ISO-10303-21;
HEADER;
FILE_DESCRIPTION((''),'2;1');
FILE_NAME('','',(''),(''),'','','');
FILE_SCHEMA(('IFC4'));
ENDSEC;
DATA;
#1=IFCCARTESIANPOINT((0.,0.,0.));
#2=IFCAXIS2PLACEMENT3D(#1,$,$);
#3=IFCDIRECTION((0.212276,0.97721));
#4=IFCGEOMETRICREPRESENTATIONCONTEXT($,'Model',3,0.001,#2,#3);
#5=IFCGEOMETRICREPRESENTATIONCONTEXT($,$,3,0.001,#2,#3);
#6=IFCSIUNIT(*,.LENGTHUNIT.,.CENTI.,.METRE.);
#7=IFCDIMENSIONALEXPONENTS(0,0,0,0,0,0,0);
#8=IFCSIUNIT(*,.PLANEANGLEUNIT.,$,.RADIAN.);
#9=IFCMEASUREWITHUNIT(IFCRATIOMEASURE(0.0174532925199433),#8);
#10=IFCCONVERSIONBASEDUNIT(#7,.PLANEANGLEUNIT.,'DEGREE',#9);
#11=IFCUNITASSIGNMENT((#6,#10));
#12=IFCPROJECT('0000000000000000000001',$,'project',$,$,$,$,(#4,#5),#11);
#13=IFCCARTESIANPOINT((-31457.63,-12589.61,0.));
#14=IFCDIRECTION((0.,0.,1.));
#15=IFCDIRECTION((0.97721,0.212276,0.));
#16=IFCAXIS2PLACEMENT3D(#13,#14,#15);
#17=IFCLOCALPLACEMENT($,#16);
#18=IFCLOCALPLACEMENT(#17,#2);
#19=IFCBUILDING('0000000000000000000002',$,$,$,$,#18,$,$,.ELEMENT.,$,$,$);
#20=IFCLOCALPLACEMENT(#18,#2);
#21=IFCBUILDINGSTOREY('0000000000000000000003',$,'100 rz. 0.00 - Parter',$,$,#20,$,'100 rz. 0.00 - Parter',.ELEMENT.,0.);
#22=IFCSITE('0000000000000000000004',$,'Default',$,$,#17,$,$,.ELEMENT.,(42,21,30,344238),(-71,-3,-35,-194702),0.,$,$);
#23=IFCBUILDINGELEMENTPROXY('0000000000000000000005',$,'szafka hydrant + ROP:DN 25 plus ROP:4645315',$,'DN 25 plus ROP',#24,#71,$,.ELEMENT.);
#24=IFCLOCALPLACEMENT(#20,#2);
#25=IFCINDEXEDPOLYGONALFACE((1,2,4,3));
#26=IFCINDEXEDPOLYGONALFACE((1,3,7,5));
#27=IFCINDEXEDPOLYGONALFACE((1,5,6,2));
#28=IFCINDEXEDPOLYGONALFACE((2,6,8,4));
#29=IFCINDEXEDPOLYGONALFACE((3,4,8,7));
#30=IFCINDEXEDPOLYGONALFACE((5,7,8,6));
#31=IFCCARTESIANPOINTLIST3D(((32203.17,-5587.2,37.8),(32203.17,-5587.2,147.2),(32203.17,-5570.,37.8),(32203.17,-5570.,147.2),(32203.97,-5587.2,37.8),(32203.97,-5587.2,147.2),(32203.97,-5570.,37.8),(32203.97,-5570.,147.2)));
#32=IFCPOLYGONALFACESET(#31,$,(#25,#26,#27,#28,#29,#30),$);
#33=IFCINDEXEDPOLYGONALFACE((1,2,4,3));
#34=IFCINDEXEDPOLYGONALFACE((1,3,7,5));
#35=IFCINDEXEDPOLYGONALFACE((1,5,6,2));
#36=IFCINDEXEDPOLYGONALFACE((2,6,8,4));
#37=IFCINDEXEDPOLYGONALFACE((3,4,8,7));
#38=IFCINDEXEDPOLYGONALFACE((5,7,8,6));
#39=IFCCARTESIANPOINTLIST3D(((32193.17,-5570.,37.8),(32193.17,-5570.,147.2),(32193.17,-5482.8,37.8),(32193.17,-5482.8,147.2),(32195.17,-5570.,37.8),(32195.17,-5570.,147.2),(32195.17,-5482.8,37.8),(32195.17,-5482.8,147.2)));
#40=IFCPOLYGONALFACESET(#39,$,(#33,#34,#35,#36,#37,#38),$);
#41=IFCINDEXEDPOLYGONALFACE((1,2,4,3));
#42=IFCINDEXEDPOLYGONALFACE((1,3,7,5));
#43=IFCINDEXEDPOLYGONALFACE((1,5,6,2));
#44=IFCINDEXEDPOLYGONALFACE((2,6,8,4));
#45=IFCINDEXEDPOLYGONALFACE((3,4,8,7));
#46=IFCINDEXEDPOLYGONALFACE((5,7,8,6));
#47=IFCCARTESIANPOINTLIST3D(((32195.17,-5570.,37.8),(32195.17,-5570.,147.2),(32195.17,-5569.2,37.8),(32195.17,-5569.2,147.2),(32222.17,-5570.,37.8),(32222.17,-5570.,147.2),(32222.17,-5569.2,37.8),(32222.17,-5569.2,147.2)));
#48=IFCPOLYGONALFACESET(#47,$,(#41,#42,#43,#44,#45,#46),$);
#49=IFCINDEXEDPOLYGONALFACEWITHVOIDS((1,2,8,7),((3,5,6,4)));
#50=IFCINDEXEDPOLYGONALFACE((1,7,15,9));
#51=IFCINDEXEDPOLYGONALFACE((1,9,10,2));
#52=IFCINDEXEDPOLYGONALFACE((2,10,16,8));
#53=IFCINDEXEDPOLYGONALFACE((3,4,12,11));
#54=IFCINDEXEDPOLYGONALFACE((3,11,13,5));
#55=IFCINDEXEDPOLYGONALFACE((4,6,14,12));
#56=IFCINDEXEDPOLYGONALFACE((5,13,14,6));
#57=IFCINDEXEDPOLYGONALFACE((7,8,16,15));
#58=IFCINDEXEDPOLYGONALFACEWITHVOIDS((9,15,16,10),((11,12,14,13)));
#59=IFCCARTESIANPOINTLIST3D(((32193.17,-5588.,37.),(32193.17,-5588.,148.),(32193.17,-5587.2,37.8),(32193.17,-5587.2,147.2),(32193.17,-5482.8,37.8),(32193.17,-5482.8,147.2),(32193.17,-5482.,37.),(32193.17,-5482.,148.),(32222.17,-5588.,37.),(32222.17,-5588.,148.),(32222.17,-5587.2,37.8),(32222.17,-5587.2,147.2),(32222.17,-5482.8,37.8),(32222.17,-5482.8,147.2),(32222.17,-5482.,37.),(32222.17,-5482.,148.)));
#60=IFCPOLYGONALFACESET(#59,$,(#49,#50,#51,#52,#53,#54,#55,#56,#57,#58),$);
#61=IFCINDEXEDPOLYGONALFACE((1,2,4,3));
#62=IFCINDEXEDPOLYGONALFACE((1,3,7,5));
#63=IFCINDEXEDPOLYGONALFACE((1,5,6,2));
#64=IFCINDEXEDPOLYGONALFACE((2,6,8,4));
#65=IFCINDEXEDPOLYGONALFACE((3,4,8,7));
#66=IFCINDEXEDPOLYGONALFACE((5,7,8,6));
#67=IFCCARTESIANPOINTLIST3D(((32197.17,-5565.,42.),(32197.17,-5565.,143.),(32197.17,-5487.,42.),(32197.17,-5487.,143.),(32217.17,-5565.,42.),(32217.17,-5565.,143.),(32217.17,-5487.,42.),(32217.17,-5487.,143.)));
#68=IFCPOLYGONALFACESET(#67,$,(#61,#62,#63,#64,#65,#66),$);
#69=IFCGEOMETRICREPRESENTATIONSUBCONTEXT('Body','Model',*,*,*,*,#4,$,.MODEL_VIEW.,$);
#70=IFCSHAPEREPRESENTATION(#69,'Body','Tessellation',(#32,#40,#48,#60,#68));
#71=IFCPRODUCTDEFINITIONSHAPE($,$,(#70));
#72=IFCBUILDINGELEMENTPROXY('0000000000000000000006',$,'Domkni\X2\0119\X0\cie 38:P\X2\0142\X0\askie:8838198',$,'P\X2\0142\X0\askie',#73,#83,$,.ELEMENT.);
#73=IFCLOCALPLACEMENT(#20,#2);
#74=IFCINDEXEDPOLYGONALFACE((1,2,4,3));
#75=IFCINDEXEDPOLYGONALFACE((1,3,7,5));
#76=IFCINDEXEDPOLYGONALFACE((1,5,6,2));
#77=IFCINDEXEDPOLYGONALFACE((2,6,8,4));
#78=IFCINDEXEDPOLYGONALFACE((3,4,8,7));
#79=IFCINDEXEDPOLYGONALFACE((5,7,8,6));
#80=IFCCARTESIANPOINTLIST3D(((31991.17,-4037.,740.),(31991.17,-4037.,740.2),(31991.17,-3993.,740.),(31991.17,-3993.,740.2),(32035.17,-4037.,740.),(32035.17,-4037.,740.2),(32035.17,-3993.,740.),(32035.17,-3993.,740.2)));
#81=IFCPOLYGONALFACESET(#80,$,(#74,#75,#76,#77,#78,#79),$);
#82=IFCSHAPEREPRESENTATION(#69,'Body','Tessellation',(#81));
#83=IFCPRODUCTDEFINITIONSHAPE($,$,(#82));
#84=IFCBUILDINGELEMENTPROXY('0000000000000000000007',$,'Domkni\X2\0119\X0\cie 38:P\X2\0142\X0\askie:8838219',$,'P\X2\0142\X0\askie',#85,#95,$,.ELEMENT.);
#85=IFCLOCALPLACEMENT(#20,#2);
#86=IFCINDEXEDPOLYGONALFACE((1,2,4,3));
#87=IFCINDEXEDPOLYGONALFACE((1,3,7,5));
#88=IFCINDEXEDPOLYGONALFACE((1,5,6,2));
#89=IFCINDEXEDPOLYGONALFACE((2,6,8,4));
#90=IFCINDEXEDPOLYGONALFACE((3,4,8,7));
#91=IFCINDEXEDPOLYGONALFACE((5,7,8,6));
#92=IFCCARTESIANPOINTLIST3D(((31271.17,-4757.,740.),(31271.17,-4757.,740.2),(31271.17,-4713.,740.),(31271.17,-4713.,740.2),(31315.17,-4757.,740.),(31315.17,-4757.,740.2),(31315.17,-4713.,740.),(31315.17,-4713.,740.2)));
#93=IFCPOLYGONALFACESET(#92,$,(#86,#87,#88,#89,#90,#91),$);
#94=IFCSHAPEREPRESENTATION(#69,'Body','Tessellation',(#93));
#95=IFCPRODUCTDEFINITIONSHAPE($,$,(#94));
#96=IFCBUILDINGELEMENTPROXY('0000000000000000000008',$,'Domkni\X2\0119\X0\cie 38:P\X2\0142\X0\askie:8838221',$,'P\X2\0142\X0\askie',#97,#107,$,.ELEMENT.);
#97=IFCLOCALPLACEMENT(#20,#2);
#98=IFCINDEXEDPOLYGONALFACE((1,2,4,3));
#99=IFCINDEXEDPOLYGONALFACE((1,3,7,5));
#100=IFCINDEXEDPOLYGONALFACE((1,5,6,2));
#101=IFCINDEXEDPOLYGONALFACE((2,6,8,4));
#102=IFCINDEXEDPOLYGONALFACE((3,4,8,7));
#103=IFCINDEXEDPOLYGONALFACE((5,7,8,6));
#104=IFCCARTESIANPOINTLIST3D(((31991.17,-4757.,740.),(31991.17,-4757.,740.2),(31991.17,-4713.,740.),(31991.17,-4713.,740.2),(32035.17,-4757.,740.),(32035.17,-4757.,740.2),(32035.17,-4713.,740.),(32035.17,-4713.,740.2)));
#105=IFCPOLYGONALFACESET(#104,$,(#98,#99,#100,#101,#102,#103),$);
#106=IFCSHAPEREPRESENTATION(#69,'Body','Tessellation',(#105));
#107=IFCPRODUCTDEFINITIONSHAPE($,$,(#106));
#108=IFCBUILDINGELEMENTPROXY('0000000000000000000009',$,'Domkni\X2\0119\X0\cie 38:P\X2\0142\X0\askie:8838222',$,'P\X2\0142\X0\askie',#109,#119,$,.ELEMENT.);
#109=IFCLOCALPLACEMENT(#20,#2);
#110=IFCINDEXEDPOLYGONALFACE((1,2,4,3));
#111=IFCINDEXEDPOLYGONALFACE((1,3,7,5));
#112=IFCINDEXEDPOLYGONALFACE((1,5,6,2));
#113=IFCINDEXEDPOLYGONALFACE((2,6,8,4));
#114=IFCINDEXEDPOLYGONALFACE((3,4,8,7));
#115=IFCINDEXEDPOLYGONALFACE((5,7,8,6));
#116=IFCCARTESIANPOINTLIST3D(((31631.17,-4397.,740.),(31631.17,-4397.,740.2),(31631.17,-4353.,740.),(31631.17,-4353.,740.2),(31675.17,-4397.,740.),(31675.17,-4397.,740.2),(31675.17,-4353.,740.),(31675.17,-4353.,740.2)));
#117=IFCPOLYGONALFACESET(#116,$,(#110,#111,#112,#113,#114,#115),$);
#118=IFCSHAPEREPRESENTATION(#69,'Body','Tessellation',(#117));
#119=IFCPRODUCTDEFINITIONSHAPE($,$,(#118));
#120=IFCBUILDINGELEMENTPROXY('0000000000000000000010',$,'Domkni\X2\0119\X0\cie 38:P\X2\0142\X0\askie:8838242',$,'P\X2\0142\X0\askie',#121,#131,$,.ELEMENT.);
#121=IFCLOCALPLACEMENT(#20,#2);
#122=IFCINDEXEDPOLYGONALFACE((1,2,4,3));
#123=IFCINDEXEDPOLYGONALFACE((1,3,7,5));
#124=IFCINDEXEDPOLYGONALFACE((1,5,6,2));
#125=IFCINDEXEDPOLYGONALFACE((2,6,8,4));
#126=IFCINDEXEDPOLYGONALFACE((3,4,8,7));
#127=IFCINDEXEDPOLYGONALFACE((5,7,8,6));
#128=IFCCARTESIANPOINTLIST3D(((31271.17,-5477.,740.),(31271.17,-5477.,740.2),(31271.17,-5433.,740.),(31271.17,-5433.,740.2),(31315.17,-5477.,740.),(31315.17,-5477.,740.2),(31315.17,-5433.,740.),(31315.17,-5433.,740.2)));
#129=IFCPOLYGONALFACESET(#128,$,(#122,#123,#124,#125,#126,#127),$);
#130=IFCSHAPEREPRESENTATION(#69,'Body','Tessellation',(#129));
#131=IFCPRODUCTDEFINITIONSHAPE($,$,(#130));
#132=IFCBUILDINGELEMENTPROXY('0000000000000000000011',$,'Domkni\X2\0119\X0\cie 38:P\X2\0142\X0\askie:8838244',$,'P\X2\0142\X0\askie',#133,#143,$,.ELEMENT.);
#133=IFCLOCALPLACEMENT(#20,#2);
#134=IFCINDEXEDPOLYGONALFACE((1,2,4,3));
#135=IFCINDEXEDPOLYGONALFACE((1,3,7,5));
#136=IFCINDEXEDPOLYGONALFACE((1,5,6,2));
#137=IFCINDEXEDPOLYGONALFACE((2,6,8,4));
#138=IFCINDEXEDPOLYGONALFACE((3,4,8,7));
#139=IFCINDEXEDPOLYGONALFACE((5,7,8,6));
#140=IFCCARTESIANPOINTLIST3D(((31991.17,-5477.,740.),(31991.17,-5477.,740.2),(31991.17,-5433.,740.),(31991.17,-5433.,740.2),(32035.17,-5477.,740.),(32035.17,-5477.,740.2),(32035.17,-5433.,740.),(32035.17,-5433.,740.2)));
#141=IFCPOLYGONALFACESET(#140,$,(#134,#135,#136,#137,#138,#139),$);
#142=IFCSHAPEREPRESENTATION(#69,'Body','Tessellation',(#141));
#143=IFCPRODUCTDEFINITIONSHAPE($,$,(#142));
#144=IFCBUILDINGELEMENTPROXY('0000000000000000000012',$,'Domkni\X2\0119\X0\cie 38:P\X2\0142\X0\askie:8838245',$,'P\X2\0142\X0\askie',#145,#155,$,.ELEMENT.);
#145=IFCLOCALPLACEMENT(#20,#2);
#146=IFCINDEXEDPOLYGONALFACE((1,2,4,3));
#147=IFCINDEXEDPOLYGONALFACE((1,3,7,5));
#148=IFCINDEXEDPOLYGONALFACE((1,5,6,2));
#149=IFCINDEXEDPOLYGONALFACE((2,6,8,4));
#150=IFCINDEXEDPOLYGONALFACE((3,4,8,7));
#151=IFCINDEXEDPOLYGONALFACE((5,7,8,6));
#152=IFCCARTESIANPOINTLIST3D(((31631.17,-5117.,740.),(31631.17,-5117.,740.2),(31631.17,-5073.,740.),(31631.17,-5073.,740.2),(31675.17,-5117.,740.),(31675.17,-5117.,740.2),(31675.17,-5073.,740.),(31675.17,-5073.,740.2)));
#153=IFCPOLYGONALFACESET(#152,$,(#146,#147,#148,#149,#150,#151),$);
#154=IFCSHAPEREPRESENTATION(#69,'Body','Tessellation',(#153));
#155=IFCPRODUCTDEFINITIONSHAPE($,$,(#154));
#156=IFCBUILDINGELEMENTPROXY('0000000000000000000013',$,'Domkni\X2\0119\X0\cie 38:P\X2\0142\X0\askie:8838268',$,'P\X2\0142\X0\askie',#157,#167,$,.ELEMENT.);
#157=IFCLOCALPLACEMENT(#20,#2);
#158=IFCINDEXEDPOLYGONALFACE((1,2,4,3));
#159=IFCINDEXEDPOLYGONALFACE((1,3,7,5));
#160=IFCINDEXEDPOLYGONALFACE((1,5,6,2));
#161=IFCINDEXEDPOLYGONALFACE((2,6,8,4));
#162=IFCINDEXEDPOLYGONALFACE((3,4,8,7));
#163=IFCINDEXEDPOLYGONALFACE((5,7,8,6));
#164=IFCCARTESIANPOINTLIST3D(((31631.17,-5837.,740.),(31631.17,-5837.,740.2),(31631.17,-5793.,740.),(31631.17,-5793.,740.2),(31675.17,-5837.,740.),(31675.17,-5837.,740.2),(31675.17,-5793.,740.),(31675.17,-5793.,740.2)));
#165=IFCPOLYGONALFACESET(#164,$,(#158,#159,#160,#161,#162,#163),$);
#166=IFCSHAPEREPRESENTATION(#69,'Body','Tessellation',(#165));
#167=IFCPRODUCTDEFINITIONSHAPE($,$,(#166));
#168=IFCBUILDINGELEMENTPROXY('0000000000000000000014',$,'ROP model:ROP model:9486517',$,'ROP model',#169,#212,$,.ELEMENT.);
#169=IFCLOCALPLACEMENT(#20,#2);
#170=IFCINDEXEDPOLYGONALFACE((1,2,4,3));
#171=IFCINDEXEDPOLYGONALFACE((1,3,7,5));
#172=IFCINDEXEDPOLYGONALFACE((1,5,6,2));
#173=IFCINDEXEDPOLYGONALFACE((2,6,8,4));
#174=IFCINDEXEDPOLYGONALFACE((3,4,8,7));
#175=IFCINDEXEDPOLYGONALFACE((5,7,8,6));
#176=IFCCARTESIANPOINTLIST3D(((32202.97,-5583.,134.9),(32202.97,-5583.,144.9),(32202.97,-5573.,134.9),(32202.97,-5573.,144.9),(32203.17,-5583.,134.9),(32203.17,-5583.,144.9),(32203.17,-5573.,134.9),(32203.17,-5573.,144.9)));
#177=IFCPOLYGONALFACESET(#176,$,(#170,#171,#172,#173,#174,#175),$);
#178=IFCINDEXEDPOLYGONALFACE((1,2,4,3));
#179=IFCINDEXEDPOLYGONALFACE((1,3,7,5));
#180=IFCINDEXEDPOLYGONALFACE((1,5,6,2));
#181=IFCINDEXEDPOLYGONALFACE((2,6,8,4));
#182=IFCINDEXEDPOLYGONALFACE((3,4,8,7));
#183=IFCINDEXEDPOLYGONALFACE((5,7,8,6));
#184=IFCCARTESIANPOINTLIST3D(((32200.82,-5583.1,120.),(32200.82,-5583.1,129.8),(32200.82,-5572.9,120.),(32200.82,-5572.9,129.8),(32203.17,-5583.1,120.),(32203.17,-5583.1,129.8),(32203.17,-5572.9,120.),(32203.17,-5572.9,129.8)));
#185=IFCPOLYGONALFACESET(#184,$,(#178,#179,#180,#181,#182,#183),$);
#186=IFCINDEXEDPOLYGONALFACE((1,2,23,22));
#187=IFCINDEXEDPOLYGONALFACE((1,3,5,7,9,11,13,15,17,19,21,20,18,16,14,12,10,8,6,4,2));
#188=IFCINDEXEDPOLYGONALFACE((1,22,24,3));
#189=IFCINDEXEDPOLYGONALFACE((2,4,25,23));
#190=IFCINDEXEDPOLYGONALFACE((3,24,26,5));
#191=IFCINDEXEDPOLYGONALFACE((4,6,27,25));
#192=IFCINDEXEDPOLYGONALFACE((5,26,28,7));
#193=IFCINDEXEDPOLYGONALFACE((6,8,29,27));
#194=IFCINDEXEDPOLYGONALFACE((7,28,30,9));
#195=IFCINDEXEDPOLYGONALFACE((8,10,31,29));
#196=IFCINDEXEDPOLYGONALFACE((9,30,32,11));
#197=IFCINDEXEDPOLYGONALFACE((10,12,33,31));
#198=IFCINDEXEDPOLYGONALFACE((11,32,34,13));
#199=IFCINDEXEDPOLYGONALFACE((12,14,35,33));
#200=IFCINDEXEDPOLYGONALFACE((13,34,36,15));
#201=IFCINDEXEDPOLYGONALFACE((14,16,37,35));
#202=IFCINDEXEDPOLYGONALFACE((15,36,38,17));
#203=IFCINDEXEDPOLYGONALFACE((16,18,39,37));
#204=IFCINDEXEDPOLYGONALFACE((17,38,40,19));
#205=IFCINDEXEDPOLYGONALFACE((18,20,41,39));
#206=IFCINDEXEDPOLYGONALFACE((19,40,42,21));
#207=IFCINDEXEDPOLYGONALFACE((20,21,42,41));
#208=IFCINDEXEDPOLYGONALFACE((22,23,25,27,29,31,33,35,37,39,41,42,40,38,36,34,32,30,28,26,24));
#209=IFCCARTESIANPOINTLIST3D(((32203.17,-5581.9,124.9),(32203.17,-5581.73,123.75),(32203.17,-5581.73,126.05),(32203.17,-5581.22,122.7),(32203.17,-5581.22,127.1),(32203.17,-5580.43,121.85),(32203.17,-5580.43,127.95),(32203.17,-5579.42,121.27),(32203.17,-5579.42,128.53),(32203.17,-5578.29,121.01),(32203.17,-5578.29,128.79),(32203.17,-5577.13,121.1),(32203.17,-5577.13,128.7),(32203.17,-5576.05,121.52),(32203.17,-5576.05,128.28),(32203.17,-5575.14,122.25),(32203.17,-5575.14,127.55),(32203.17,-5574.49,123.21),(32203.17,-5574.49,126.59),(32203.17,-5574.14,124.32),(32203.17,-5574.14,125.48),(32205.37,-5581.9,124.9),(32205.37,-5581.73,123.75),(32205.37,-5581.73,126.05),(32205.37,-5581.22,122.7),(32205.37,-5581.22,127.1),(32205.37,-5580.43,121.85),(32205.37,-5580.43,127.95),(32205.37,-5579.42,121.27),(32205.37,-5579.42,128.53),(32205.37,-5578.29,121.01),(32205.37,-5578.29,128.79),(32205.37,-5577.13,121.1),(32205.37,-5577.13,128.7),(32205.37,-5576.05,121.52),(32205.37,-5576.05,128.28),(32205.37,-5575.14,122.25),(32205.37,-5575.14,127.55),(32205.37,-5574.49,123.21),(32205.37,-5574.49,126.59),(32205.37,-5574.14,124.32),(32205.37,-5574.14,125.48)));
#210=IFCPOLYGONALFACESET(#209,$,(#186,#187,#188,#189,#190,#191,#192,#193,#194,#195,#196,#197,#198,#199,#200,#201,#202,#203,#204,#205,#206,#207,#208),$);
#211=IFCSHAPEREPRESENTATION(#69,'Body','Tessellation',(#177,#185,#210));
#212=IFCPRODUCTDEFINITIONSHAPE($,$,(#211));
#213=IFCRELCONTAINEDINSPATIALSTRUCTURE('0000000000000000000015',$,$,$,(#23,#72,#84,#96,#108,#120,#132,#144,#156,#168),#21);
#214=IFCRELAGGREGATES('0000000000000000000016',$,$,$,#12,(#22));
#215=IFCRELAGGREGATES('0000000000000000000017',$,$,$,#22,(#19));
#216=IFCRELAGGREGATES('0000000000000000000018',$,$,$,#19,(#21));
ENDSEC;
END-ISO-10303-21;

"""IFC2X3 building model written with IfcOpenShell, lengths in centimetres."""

from ifc_helpers import new_model, entity, si_unit, converted_unit, direction, frame, frame_2d, origin, origin_2d_with_axis, place, context, subcontext, project, spatial, polyline, rectangle, circle, outline, extrude, source, transform, mapped, element, save


model = new_model("IFC2X3")

# Units and contexts
model_context = context("Model", 3, precision=0.001, world=origin(), true_north=direction((0.212276, 0.97721)))
context_of_model = context(None, 3, precision=0.001, world=origin(), true_north=direction((0.212276, 0.97721)))
body_context = subcontext(model_context, "Body", "Model", "MODEL_VIEW")
ifc_project = project(units=[si_unit("LENGTHUNIT", "METRE", prefix="CENTI"), converted_unit("PLANEANGLEUNIT", "DEGREE", entity("IfcRatioMeasure", 0.0174532925199433), si_unit("PLANEANGLEUNIT", "RADIAN"), dimensions=[0, 0, 0, 0, 0, 0, 0])], contexts=[model_context, context_of_model])

# Site, building, storey
site_placement = place(None, frame((-31457.63, -12589.61, 0.0), z_axis=(0.0, 0.0, 1.0), x_axis=(0.97721, 0.212276, 0.0)))
site = spatial("IfcSite", under=ifc_project, at=site_placement, Name="Default", CompositionType="ELEMENT", RefLatitude=(42, 21, 30, 344238), RefLongitude=(-71, -3, -35, -194702), RefElevation=0.0)
building_placement = place(site_placement, origin())
building = spatial("IfcBuilding", under=site, at=building_placement, CompositionType="ELEMENT")
storey_placement = place(building_placement, origin())
storey = spatial("IfcBuildingStorey", under=building, at=storey_placement, Name="100 rz. 0.00 - Parter", LongName="100 rz. 0.00 - Parter", CompositionType="ELEMENT", Elevation=0.0)

# Building element proxies
shared_shape_1 = source(origin(), body_context, "Body", "SweptSolid", [
    extrude(rectangle(XDim=17.2, YDim=0.8, at=frame_2d((0.0, 0.0), x_axis=(1.0, 0.0))), frame((96.6, 10.4, 0.8), z_axis=(0.0, 0.0, 1.0), x_axis=(-1.0, 0.0, 0.0)), (0.0, 0.0, 1.0), 109.4),
    extrude(rectangle(XDim=87.2, YDim=2.0, at=origin_2d_with_axis()), frame((44.4, 1.0, 0.8), z_axis=(0.0, 0.0, 1.0), x_axis=(-1.0, 0.0, 0.0)), (0.0, 0.0, 1.0), 109.4),
    extrude(rectangle(XDim=0.8, YDim=27.0, at=origin_2d_with_axis()), frame((87.6, 15.5, 0.8), z_axis=(0.0, 0.0, 1.0), x_axis=(-1.0, 0.0, 0.0)), (0.0, 0.0, 1.0), 109.4),
    extrude(outline(polyline([(-55.5, -53.0), (55.5, -53.0), (55.5, 53.0), (-55.5, 53.0), (-55.5, -53.0)]), holes=[polyline([(-54.7, -52.2), (-54.7, 52.2), (54.7, 52.2), (54.7, -52.2), (-54.7, -52.2)])]), frame((53.0, 0.0, 55.5), z_axis=(0.0, 1.0, 0.0), x_axis=(0.0, 0.0, -1.0)), (0.0, 0.0, 1.0), 29.0),
    extrude(rectangle(XDim=78.0, YDim=20.0, at=origin_2d_with_axis()), frame((44.0, 14.0, 5.0), z_axis=(0.0, 0.0, 1.0), x_axis=(-1.0, 0.0, 0.0)), (0.0, 0.0, 1.0), 101.0),
])
proxy_1_placement = place(storey_placement, frame((32193.17, -5482.0, 37.0), z_axis=(0.0, 0.0, 1.0), x_axis=(0.0, -1.0, 0.0)))
element("IfcBuildingElementProxy", 1, at=proxy_1_placement, inside=storey, Name="szafka hydrant + ROP:DN 25 plus ROP:4645315", ObjectType="DN 25 plus ROP", CompositionType="ELEMENT", context=body_context, shape_type="MappedRepresentation", body=[
    mapped(shared_shape_1, transform((0.0, 0.0, 0.0), scale=1.0)),
])
shared_shape_2 = source(origin(), body_context, "Body", "SweptSolid", [
    extrude(rectangle(XDim=44.0, YDim=44.0, at=origin_2d_with_axis()), frame((22.0, 22.0, 0.0), z_axis=(0.0, 0.0, 1.0), x_axis=(-1.0, 0.0, 0.0)), (0.0, 0.0, 1.0), 0.2),
])
for number, where, name in (
    (2, (31991.17, -4037.0, 740.0), "Domknięcie 38:Płaskie:8838198"),
    (3, (31271.17, -4757.0, 740.0), "Domknięcie 38:Płaskie:8838219"),
    (4, (31991.17, -4757.0, 740.0), "Domknięcie 38:Płaskie:8838221"),
    (5, (31631.17, -4397.0, 740.0), "Domknięcie 38:Płaskie:8838222"),
    (6, (31271.17, -5477.0, 740.0), "Domknięcie 38:Płaskie:8838242"),
    (7, (31991.17, -5477.0, 740.0), "Domknięcie 38:Płaskie:8838244"),
    (8, (31631.17, -5117.0, 740.0), "Domknięcie 38:Płaskie:8838245"),
    (9, (31631.17, -5837.0, 740.0), "Domknięcie 38:Płaskie:8838268"),
):
    element("IfcBuildingElementProxy", number, at=place(storey_placement, frame(where)), inside=storey, Name=name, ObjectType="Płaskie", CompositionType="ELEMENT", context=body_context, shape_type="MappedRepresentation", body=[
        mapped(shared_shape_2, transform((0.0, 0.0, 0.0), scale=1.0)),
    ])
shared_shape_3 = source(origin(), body_context, "Body", "SweptSolid", [
    extrude(rectangle(XDim=0.2, YDim=10.0, at=origin_2d_with_axis()), frame((5.1, 2.25, 14.9), z_axis=(0.0, 0.0, 1.0), x_axis=(0.0, 1.0, 0.0)), (0.0, 0.0, 1.0), 10.0),
    extrude(rectangle(XDim=2.35, YDim=10.2, at=origin_2d_with_axis()), frame((5.1, 1.18, 0.0), z_axis=(0.0, 0.0, 1.0), x_axis=(0.0, 1.0, 0.0)), (0.0, 0.0, 1.0), 9.8),
    extrude(circle(Radius=3.9, at=frame_2d((0.0, 0.0), x_axis=(1.0, 0.0))), frame((5.1, 2.35, 4.9), z_axis=(0.0, 1.0, 0.0), x_axis=(1.0, 0.0, 0.0)), (0.0, 0.0, 1.0), 2.2),
])
proxy_2_placement = place(storey_placement, frame((32200.82, -5572.9, 120.0), z_axis=(0.0, 0.0, 1.0), x_axis=(0.0, -1.0, 0.0)))
element("IfcBuildingElementProxy", 10, at=proxy_2_placement, inside=storey, Name="ROP model:ROP model:9486517", ObjectType="ROP model", CompositionType="ELEMENT", context=body_context, shape_type="MappedRepresentation", body=[
    mapped(shared_shape_3, transform((0.0, 0.0, 0.0), scale=1.0)),
])

save(model, "model.ifc")
